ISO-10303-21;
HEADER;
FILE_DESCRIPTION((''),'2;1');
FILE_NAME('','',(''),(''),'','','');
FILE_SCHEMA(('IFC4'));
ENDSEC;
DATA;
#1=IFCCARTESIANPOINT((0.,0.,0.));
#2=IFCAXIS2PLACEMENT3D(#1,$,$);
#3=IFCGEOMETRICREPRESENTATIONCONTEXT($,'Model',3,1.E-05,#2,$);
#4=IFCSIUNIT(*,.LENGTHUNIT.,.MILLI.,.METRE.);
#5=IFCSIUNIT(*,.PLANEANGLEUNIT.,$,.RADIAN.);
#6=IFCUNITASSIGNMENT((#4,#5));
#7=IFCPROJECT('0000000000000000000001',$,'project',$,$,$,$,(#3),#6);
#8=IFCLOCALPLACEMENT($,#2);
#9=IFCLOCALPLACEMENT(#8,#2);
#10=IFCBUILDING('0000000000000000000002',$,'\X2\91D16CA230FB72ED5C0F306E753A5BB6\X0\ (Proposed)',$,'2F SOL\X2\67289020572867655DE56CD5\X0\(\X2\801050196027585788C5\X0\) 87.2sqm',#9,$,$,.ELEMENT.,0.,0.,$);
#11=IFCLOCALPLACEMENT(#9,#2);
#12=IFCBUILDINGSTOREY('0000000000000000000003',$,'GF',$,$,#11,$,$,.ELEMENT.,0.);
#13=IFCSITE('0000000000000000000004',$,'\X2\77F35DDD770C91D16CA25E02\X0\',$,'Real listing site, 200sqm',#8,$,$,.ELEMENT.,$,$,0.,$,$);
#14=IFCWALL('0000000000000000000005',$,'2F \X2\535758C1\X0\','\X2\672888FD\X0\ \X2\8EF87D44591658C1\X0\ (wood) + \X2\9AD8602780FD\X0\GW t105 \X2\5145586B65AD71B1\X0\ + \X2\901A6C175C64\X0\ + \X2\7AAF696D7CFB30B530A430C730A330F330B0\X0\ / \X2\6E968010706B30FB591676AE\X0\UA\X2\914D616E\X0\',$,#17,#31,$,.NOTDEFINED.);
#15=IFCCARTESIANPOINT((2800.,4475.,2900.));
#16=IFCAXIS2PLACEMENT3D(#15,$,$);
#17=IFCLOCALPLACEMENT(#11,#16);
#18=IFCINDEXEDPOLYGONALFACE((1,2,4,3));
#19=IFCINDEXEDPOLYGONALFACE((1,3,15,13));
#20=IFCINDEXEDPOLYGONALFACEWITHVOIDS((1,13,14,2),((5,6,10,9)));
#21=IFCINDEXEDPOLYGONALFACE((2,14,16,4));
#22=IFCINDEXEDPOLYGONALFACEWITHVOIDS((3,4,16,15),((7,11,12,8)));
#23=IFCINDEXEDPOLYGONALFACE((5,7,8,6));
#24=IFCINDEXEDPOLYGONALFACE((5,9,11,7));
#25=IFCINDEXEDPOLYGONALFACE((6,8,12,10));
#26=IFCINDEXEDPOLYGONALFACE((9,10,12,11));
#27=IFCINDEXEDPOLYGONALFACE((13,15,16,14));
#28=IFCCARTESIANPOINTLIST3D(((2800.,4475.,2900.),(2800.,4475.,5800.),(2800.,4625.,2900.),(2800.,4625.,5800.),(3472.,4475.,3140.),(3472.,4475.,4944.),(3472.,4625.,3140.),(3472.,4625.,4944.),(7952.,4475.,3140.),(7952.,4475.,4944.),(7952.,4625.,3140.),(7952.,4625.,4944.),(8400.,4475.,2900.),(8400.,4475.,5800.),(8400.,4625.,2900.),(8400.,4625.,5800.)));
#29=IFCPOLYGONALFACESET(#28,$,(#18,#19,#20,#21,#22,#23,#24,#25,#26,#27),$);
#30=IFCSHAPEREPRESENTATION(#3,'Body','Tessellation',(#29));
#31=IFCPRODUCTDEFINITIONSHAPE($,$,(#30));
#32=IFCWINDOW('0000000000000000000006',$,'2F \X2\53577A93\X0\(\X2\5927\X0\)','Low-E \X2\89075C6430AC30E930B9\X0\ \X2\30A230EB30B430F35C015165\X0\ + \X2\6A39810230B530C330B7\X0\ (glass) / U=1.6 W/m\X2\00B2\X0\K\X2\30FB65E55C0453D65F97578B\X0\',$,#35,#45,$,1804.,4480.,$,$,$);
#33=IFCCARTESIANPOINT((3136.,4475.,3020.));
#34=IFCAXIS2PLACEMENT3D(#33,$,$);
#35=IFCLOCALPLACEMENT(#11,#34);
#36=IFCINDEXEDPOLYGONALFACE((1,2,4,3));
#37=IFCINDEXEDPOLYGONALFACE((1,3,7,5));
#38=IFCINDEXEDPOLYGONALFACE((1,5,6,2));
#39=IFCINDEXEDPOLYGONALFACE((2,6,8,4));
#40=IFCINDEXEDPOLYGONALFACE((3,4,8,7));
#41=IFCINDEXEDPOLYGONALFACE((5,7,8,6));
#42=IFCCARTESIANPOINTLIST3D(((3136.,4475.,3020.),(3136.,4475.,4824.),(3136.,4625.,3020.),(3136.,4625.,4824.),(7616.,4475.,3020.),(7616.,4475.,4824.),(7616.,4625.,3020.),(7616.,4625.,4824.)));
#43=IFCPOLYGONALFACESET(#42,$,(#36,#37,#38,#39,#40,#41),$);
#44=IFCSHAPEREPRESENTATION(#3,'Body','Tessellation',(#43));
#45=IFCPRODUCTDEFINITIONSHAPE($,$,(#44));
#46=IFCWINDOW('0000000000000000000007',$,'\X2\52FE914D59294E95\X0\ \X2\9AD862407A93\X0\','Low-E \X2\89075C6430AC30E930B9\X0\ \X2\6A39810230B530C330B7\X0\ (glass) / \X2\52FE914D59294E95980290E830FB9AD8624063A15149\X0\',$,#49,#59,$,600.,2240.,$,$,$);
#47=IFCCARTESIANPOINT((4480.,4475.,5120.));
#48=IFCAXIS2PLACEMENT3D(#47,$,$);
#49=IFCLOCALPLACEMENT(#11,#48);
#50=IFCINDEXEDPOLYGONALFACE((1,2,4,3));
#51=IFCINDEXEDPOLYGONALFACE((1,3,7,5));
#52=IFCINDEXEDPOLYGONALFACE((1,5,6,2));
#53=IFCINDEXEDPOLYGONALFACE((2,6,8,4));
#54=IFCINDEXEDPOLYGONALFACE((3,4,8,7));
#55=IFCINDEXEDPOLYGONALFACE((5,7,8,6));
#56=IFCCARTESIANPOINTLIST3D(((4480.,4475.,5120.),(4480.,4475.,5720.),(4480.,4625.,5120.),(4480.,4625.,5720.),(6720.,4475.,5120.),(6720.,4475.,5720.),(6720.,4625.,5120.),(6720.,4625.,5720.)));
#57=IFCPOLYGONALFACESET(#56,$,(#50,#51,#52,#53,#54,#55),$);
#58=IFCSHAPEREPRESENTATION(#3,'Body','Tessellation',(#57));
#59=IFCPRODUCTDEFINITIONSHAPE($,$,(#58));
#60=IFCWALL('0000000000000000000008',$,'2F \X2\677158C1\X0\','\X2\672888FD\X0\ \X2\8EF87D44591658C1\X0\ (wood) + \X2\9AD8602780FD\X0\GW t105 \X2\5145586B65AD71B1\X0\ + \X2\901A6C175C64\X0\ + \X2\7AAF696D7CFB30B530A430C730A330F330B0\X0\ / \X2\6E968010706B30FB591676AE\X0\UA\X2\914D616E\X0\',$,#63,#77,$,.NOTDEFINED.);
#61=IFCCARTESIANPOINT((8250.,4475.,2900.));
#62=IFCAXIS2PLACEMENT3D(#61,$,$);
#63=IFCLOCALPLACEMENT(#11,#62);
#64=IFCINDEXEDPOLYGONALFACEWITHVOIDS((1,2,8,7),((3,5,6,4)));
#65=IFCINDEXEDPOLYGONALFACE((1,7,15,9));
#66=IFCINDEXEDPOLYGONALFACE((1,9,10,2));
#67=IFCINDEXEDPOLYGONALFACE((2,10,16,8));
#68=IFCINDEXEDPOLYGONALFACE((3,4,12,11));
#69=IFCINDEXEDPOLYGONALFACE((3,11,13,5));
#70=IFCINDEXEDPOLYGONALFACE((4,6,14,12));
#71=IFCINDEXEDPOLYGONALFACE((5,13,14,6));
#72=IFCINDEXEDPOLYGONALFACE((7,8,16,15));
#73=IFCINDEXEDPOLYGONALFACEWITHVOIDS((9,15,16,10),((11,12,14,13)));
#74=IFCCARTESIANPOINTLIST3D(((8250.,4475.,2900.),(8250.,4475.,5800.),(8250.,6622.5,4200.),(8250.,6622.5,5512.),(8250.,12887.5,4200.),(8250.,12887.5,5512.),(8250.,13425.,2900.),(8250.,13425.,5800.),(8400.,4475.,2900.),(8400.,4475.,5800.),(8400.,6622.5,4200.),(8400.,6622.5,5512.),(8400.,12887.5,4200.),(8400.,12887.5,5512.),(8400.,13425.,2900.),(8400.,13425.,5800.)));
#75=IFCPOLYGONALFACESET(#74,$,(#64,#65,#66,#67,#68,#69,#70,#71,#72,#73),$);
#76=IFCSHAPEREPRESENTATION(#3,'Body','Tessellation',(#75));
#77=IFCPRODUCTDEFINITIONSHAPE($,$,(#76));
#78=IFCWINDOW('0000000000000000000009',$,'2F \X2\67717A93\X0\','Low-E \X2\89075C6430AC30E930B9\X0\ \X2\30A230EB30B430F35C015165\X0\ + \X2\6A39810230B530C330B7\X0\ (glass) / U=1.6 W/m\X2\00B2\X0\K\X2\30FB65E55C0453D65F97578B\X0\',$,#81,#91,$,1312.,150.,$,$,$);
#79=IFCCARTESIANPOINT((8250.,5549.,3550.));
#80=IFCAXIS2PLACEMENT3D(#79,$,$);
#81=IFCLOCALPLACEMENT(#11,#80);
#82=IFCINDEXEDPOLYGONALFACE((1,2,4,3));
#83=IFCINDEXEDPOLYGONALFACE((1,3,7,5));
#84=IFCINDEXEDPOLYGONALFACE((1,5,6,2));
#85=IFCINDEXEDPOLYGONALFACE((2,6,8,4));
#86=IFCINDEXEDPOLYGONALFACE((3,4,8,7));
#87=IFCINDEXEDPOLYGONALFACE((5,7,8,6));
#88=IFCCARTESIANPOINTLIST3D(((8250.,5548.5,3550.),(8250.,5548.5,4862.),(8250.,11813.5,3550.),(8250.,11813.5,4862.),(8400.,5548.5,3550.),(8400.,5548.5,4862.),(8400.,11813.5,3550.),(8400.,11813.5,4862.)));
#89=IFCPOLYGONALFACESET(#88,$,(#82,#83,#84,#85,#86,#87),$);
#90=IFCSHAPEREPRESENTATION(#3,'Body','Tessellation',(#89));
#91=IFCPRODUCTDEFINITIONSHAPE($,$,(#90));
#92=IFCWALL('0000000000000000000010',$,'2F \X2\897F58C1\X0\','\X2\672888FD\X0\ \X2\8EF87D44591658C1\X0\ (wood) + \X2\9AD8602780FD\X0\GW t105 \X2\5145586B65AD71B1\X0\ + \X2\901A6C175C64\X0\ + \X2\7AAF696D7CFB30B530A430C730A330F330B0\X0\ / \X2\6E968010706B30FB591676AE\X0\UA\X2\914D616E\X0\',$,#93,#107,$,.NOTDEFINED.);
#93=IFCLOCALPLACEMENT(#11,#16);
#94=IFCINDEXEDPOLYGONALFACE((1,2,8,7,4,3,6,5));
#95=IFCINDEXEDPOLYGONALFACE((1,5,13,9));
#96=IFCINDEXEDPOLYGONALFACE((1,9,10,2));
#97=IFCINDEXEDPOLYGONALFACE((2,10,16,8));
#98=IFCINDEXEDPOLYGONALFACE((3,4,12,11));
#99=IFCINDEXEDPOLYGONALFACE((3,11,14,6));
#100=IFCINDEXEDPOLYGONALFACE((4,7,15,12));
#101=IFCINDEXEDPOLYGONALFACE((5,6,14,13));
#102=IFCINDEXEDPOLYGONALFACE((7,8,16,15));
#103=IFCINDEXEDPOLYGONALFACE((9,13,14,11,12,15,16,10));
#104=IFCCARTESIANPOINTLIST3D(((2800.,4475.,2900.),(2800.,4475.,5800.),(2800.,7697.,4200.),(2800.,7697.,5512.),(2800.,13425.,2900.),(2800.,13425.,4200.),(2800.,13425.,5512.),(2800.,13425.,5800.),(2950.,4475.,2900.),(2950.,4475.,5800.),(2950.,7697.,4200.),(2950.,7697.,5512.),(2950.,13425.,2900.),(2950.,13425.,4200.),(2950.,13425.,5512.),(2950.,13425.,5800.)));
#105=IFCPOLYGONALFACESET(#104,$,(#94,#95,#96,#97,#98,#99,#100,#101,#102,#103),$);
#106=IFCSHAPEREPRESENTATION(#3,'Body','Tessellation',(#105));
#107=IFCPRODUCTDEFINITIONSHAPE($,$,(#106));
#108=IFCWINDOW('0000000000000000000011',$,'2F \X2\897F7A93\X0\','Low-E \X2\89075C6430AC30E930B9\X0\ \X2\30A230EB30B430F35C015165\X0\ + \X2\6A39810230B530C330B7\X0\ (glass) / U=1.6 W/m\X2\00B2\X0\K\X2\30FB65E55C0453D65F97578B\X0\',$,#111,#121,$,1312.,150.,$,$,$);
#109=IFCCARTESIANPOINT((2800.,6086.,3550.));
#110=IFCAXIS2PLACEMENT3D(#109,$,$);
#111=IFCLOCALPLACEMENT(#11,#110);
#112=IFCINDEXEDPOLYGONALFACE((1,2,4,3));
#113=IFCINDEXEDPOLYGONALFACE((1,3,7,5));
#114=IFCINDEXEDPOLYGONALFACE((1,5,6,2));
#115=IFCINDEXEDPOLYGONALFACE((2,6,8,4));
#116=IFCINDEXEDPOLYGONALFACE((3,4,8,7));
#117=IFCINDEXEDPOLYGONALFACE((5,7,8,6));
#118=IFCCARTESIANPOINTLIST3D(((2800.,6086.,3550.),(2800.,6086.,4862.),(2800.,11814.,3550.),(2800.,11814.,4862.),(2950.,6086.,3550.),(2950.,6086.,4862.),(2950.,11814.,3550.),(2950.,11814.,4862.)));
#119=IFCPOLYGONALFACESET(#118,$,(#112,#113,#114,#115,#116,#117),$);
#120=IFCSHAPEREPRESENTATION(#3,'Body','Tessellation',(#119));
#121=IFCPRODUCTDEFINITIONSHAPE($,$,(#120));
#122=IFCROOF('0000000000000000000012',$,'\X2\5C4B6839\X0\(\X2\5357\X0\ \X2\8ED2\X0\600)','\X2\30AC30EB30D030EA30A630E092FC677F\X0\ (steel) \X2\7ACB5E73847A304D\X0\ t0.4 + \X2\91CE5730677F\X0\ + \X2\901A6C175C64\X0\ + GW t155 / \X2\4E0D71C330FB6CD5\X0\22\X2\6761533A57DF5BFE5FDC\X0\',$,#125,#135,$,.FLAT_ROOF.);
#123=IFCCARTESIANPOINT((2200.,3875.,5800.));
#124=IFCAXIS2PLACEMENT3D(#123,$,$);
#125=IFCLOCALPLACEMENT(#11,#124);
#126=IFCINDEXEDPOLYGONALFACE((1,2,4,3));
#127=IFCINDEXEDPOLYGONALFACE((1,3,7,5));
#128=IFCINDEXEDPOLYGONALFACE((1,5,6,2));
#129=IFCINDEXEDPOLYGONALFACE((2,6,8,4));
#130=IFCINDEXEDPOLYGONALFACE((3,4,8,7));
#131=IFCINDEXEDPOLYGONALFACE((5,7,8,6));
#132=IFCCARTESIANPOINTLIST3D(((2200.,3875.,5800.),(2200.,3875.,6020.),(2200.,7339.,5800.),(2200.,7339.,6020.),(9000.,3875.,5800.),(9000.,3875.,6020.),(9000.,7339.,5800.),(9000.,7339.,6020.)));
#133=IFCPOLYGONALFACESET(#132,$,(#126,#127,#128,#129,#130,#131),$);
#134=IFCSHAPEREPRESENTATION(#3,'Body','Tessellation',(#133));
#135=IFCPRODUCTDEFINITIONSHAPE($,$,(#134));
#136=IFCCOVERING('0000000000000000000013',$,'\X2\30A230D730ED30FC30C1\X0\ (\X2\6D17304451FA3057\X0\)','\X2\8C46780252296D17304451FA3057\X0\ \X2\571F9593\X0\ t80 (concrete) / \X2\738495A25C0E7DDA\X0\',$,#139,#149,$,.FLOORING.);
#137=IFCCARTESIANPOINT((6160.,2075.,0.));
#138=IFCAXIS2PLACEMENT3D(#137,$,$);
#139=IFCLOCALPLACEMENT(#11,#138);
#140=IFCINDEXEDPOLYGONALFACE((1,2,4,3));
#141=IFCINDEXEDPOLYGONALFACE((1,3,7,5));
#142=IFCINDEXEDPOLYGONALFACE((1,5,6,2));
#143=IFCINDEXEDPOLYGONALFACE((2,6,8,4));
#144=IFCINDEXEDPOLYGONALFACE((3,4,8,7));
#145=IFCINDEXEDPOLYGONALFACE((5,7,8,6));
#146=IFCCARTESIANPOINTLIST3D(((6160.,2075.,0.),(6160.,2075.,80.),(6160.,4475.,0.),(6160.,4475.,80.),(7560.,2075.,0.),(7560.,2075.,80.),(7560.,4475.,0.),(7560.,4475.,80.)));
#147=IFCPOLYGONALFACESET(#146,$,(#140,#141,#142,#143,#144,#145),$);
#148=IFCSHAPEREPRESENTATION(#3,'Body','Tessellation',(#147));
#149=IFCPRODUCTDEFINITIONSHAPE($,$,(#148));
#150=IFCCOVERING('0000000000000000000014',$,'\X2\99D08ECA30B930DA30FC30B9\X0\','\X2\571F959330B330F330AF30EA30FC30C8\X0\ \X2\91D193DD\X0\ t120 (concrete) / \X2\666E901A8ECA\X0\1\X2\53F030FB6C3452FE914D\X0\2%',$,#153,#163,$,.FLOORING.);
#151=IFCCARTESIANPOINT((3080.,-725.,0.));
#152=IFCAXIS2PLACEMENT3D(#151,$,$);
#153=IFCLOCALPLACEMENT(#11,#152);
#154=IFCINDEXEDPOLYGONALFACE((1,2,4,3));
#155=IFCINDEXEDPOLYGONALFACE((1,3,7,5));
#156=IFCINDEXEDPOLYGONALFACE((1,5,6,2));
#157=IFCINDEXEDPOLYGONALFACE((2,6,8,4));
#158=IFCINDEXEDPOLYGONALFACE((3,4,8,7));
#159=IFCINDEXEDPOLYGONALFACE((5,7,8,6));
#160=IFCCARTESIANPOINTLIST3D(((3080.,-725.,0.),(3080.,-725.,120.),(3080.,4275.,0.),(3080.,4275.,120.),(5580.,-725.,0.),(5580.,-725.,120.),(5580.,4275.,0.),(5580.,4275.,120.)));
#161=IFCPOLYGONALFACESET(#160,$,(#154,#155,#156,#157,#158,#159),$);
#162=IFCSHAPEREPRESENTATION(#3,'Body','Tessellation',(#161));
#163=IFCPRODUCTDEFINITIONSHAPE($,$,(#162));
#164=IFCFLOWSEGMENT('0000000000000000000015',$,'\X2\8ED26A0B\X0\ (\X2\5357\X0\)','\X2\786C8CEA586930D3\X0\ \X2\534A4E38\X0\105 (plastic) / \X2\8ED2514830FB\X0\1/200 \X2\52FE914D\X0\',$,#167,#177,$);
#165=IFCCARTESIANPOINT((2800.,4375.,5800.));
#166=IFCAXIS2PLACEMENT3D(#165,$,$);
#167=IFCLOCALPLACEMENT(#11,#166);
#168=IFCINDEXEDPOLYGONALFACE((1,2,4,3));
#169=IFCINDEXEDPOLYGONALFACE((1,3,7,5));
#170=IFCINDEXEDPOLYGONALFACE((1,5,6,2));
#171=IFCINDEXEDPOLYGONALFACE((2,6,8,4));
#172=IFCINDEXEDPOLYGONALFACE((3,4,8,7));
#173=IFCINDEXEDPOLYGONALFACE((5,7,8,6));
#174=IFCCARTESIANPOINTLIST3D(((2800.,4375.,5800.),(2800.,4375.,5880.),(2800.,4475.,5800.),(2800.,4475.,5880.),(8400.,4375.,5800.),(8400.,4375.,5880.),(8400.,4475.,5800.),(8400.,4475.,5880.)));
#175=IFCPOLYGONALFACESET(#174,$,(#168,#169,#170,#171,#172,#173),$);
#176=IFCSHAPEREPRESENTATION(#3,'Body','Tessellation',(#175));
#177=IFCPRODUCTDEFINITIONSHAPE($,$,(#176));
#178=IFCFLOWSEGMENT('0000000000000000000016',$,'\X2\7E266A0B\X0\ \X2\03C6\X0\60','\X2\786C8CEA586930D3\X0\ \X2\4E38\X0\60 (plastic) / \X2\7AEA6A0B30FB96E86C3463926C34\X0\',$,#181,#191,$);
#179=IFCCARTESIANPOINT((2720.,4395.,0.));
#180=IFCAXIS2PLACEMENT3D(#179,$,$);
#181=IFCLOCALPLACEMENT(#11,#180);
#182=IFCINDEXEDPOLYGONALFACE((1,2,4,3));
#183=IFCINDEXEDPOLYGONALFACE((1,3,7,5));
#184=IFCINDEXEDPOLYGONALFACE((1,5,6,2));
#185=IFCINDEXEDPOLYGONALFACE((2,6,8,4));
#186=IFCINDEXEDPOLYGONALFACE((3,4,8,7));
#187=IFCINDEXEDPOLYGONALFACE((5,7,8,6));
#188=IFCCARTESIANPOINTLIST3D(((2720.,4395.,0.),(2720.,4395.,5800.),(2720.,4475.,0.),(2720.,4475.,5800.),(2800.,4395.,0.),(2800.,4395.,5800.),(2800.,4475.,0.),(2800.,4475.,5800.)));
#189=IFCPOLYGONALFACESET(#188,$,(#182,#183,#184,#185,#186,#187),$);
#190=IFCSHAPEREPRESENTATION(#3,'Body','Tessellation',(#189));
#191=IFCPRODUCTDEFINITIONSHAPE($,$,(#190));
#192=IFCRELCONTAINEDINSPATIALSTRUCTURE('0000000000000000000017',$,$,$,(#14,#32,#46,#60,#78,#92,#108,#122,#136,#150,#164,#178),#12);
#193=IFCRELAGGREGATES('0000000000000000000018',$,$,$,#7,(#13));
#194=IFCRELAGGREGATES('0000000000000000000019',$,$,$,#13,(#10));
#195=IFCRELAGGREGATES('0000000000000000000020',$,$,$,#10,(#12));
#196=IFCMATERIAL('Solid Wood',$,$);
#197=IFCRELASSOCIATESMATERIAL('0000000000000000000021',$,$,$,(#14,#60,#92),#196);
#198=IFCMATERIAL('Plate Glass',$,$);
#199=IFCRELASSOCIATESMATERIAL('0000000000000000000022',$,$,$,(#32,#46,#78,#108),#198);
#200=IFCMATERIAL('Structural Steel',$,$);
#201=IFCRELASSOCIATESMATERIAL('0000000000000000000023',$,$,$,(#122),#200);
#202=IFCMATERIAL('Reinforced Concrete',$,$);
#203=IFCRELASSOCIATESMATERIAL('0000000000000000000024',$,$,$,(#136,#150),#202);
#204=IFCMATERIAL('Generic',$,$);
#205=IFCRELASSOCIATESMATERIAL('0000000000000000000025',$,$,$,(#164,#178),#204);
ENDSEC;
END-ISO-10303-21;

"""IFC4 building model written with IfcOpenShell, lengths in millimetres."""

from ifc_helpers import new_model, si_unit, frame, frame_2d, origin, place, context, project, spatial, rectangle, extrude, material, element, fill, save


model = new_model("IFC4")

# Units and contexts
model_context = context("Model", 3, precision=1e-05, world=origin())
ifc_project = project(units=[si_unit("LENGTHUNIT", "METRE", prefix="MILLI"), si_unit("PLANEANGLEUNIT", "RADIAN")], contexts=[model_context])

# Site, building, storey
site_placement = place(None, origin())
site = spatial("IfcSite", under=ifc_project, at=site_placement, Name="石川県金沢市", ObjectType="Real listing site, 200sqm", CompositionType="ELEMENT", RefElevation=0.0)
building_placement = place(site_placement, origin())
building = spatial("IfcBuilding", under=site, at=building_placement, Name="金沢・狭小の町家 (Proposed)", ObjectType="2F SOL木造在来工法(耐候性塗装) 87.2sqm", CompositionType="ELEMENT", ElevationOfRefHeight=0.0, ElevationOfTerrain=0.0)
storey_placement = place(building_placement, origin())
storey = spatial("IfcBuildingStorey", under=building, at=storey_placement, Name="GF", CompositionType="ELEMENT", Elevation=0.0)

# Shared definitions
ifc_material_1 = material(Name="Solid Wood")

# Shared definitions
ifc_material_2 = material(Name="Reinforced Concrete")

# Shared definitions
ifc_material_3 = material(Name="Plate Glass")

# Wall, openings, windows
wall_1_placement = place(storey_placement, frame((2800.0, 4475.0, 2900.0)))
wall_1 = element("IfcWall", 1, at=wall_1_placement, inside=storey, material=ifc_material_1, Name="2F 南壁", Description="木製 軸組外壁 (wood) + 高性能GW t105 充填断熱 + 通気層 + 窯業系サイディング / 準耐火・外皮UA配慮", PredefinedType="NOTDEFINED", context=model_context, shape_type="SweptSolid", body=[
    extrude(rectangle(XDim=5600.0, YDim=150.0, at=frame_2d((2800.0, 75.0))), frame((2800.0, 4475.0, 2900.0)), (0.0, 0.0, 1.0), 2900.0),
])
opening_1_placement = place(storey_placement, frame((3136.0, 4475.0, 3020.0)))
opening_1 = element("IfcOpeningElement", 2, at=opening_1_placement, cuts=wall_1, PredefinedType="NOTDEFINED", context=model_context, shape_type="SweptSolid", body=[
    extrude(rectangle(XDim=4480.0, YDim=150.0, at=frame_2d((2240.0, 75.0))), frame((3136.0, 4475.0, 3020.0)), (0.0, 0.0, 1.0), 1804.0),
])
opening_2_placement = place(storey_placement, frame((4480.0, 4475.0, 5120.0)))
opening_2 = element("IfcOpeningElement", 3, at=opening_2_placement, cuts=wall_1, PredefinedType="NOTDEFINED", context=model_context, shape_type="SweptSolid", body=[
    extrude(rectangle(XDim=2240.0, YDim=150.0, at=frame_2d((1120.0, 75.0))), frame((4480.0, 4475.0, 5120.0)), (0.0, 0.0, 1.0), 600.0),
])
window_1_placement = place(storey_placement, frame((3136.0, 4475.0, 3020.0)))
window_1 = element("IfcWindow", 4, at=window_1_placement, inside=storey, material=ifc_material_3, Name="2F 南窓(大)", Description="Low-E 複層ガラス アルゴン封入 + 樹脂サッシ (glass) / U=1.6 W/m²K・日射取得型", OverallHeight=1804.0, OverallWidth=4480.0, context=model_context, shape_type="SweptSolid", body=[
    extrude(rectangle(XDim=4480.0, YDim=150.0, at=frame_2d((2240.0, 75.0))), frame((3136.0, 4475.0, 3020.0)), (0.0, 0.0, 1.0), 1804.0),
])
fill(opening_1, window_1)
window_2_placement = place(storey_placement, frame((4480.0, 4475.0, 5120.0)))
window_2 = element("IfcWindow", 5, at=window_2_placement, inside=storey, material=ifc_material_3, Name="勾配天井 高所窓", Description="Low-E 複層ガラス 樹脂サッシ (glass) / 勾配天井頂部・高所採光", OverallHeight=600.0, OverallWidth=2240.0, context=model_context, shape_type="SweptSolid", body=[
    extrude(rectangle(XDim=2240.0, YDim=150.0, at=frame_2d((1120.0, 75.0))), frame((4480.0, 4475.0, 5120.0)), (0.0, 0.0, 1.0), 600.0),
])
fill(opening_2, window_2)

# Walls, openings, windows
wall_2_placement = place(storey_placement, frame((8250.0, 4475.0, 2900.0)))
wall_2 = element("IfcWall", 6, at=wall_2_placement, inside=storey, material=ifc_material_1, Name="2F 東壁", Description="木製 軸組外壁 (wood) + 高性能GW t105 充填断熱 + 通気層 + 窯業系サイディング / 準耐火・外皮UA配慮", PredefinedType="NOTDEFINED", context=model_context, shape_type="SweptSolid", body=[
    extrude(rectangle(XDim=150.0, YDim=8950.0, at=frame_2d((75.0, 4475.0))), frame((8250.0, 4475.0, 2900.0)), (0.0, 0.0, 1.0), 2900.0),
])
opening_3_placement = place(storey_placement, frame((8250.0, 5549.0, 3550.0)))
opening_3 = element("IfcOpeningElement", 7, at=opening_3_placement, cuts=wall_2, PredefinedType="NOTDEFINED", context=model_context, shape_type="SweptSolid", body=[
    extrude(rectangle(XDim=150.0, YDim=6265.0, at=frame_2d((75.0, 3132.0))), frame((8250.0, 5549.0, 3550.0)), (0.0, 0.0, 1.0), 1312.0),
])
window_3_placement = place(storey_placement, frame((8250.0, 5549.0, 3550.0)))
window_3 = element("IfcWindow", 8, at=window_3_placement, inside=storey, material=ifc_material_3, Name="2F 東窓", Description="Low-E 複層ガラス アルゴン封入 + 樹脂サッシ (glass) / U=1.6 W/m²K・日射取得型", OverallHeight=1312.0, OverallWidth=150.0, context=model_context, shape_type="SweptSolid", body=[
    extrude(rectangle(XDim=150.0, YDim=6265.0, at=frame_2d((75.0, 3132.0))), frame((8250.0, 5549.0, 3550.0)), (0.0, 0.0, 1.0), 1312.0),
])
fill(opening_3, window_3)
wall_3_placement = place(storey_placement, frame((2800.0, 4475.0, 2900.0)))
wall_3 = element("IfcWall", 9, at=wall_3_placement, inside=storey, material=ifc_material_1, Name="2F 西壁", Description="木製 軸組外壁 (wood) + 高性能GW t105 充填断熱 + 通気層 + 窯業系サイディング / 準耐火・外皮UA配慮", PredefinedType="NOTDEFINED", context=model_context, shape_type="SweptSolid", body=[
    extrude(rectangle(XDim=150.0, YDim=8950.0, at=frame_2d((75.0, 4475.0))), frame((2800.0, 4475.0, 2900.0)), (0.0, 0.0, 1.0), 2900.0),
])
opening_4_placement = place(storey_placement, frame((2800.0, 6086.0, 3550.0)))
opening_4 = element("IfcOpeningElement", 10, at=opening_4_placement, cuts=wall_3, PredefinedType="NOTDEFINED", context=model_context, shape_type="SweptSolid", body=[
    extrude(rectangle(XDim=150.0, YDim=5728.0, at=frame_2d((75.0, 2864.0))), frame((2800.0, 6086.0, 3550.0)), (0.0, 0.0, 1.0), 1312.0),
])
window_4_placement = place(storey_placement, frame((2800.0, 6086.0, 3550.0)))
window_4 = element("IfcWindow", 11, at=window_4_placement, inside=storey, material=ifc_material_3, Name="2F 西窓", Description="Low-E 複層ガラス アルゴン封入 + 樹脂サッシ (glass) / U=1.6 W/m²K・日射取得型", OverallHeight=1312.0, OverallWidth=150.0, context=model_context, shape_type="SweptSolid", body=[
    extrude(rectangle(XDim=150.0, YDim=5728.0, at=frame_2d((75.0, 2864.0))), frame((2800.0, 6086.0, 3550.0)), (0.0, 0.0, 1.0), 1312.0),
])
fill(opening_4, window_4)

# Roof
ifc_material_4 = material(Name="Structural Steel")
for number, where, name in (
    (12, (2200.0, 3875.0, 5800.0), "屋根(南 軒600)"),
):
    element("IfcRoof", number, at=place(storey_placement, frame(where)), inside=storey, material=ifc_material_4, Name=name, Description="ガルバリウム鋼板 (steel) 立平葺き t0.4 + 野地板 + 通気層 + GW t155 / 不燃・法22条区域対応", PredefinedType="FLAT_ROOF", context=model_context, shape_type="SweptSolid", body=[
        extrude(rectangle(XDim=6800.0, YDim=3464.0, at=frame_2d((3400.0, 1732.0))), frame((2200.0, 3875.0, 5800.0)), (0.0, 0.0, 1.0), 220.0),
    ])

# Coverings
covering_1_placement = place(storey_placement, frame((6160.0, 2075.0, 0.0)))
element("IfcCovering", 13, at=covering_1_placement, inside=storey, material=ifc_material_2, Name="アプローチ (洗い出し)", Description="豆砂利洗い出し 土間 t80 (concrete) / 玄関導線", PredefinedType="FLOORING", context=model_context, shape_type="SweptSolid", body=[
    extrude(rectangle(XDim=1400.0, YDim=2400.0, at=frame_2d((700.0, 1200.0))), frame((6160.0, 2075.0, 0.0)), (0.0, 0.0, 1.0), 80.0),
])
covering_2_placement = place(storey_placement, frame((3080.0, -725.0, 0.0)))
element("IfcCovering", 14, at=covering_2_placement, inside=storey, material=ifc_material_2, Name="駐車スペース", Description="土間コンクリート 金鏝 t120 (concrete) / 普通車1台・水勾配2%", PredefinedType="FLOORING", context=model_context, shape_type="SweptSolid", body=[
    extrude(rectangle(XDim=2500.0, YDim=5000.0, at=frame_2d((1250.0, 2500.0))), frame((3080.0, -725.0, 0.0)), (0.0, 0.0, 1.0), 120.0),
])

# Flow segments
ifc_material_5 = material(Name="Generic")
flow_segment_1_placement = place(storey_placement, frame((2800.0, 4375.0, 5800.0)))
element("IfcFlowSegment", 15, at=flow_segment_1_placement, inside=storey, material=ifc_material_5, Name="軒樋 (南)", Description="硬質塩ビ 半丸105 (plastic) / 軒先・1/200 勾配", context=model_context, shape_type="SweptSolid", body=[
    extrude(rectangle(XDim=5600.0, YDim=100.0, at=frame_2d((2800.0, 50.0))), frame((2800.0, 4375.0, 5800.0)), (0.0, 0.0, 1.0), 80.0),
])
flow_segment_2_placement = place(storey_placement, frame((2720.0, 4395.0, 0.0)))
element("IfcFlowSegment", 16, at=flow_segment_2_placement, inside=storey, material=ifc_material_5, Name="縦樋 φ60", Description="硬質塩ビ 丸60 (plastic) / 竪樋・雨水排水", context=model_context, shape_type="SweptSolid", body=[
    extrude(rectangle(XDim=80.0, YDim=80.0, at=frame_2d((40.0, 40.0))), frame((2720.0, 4395.0, 0.0)), (0.0, 0.0, 1.0), 5800.0),
])

save(model, "model.ifc")
